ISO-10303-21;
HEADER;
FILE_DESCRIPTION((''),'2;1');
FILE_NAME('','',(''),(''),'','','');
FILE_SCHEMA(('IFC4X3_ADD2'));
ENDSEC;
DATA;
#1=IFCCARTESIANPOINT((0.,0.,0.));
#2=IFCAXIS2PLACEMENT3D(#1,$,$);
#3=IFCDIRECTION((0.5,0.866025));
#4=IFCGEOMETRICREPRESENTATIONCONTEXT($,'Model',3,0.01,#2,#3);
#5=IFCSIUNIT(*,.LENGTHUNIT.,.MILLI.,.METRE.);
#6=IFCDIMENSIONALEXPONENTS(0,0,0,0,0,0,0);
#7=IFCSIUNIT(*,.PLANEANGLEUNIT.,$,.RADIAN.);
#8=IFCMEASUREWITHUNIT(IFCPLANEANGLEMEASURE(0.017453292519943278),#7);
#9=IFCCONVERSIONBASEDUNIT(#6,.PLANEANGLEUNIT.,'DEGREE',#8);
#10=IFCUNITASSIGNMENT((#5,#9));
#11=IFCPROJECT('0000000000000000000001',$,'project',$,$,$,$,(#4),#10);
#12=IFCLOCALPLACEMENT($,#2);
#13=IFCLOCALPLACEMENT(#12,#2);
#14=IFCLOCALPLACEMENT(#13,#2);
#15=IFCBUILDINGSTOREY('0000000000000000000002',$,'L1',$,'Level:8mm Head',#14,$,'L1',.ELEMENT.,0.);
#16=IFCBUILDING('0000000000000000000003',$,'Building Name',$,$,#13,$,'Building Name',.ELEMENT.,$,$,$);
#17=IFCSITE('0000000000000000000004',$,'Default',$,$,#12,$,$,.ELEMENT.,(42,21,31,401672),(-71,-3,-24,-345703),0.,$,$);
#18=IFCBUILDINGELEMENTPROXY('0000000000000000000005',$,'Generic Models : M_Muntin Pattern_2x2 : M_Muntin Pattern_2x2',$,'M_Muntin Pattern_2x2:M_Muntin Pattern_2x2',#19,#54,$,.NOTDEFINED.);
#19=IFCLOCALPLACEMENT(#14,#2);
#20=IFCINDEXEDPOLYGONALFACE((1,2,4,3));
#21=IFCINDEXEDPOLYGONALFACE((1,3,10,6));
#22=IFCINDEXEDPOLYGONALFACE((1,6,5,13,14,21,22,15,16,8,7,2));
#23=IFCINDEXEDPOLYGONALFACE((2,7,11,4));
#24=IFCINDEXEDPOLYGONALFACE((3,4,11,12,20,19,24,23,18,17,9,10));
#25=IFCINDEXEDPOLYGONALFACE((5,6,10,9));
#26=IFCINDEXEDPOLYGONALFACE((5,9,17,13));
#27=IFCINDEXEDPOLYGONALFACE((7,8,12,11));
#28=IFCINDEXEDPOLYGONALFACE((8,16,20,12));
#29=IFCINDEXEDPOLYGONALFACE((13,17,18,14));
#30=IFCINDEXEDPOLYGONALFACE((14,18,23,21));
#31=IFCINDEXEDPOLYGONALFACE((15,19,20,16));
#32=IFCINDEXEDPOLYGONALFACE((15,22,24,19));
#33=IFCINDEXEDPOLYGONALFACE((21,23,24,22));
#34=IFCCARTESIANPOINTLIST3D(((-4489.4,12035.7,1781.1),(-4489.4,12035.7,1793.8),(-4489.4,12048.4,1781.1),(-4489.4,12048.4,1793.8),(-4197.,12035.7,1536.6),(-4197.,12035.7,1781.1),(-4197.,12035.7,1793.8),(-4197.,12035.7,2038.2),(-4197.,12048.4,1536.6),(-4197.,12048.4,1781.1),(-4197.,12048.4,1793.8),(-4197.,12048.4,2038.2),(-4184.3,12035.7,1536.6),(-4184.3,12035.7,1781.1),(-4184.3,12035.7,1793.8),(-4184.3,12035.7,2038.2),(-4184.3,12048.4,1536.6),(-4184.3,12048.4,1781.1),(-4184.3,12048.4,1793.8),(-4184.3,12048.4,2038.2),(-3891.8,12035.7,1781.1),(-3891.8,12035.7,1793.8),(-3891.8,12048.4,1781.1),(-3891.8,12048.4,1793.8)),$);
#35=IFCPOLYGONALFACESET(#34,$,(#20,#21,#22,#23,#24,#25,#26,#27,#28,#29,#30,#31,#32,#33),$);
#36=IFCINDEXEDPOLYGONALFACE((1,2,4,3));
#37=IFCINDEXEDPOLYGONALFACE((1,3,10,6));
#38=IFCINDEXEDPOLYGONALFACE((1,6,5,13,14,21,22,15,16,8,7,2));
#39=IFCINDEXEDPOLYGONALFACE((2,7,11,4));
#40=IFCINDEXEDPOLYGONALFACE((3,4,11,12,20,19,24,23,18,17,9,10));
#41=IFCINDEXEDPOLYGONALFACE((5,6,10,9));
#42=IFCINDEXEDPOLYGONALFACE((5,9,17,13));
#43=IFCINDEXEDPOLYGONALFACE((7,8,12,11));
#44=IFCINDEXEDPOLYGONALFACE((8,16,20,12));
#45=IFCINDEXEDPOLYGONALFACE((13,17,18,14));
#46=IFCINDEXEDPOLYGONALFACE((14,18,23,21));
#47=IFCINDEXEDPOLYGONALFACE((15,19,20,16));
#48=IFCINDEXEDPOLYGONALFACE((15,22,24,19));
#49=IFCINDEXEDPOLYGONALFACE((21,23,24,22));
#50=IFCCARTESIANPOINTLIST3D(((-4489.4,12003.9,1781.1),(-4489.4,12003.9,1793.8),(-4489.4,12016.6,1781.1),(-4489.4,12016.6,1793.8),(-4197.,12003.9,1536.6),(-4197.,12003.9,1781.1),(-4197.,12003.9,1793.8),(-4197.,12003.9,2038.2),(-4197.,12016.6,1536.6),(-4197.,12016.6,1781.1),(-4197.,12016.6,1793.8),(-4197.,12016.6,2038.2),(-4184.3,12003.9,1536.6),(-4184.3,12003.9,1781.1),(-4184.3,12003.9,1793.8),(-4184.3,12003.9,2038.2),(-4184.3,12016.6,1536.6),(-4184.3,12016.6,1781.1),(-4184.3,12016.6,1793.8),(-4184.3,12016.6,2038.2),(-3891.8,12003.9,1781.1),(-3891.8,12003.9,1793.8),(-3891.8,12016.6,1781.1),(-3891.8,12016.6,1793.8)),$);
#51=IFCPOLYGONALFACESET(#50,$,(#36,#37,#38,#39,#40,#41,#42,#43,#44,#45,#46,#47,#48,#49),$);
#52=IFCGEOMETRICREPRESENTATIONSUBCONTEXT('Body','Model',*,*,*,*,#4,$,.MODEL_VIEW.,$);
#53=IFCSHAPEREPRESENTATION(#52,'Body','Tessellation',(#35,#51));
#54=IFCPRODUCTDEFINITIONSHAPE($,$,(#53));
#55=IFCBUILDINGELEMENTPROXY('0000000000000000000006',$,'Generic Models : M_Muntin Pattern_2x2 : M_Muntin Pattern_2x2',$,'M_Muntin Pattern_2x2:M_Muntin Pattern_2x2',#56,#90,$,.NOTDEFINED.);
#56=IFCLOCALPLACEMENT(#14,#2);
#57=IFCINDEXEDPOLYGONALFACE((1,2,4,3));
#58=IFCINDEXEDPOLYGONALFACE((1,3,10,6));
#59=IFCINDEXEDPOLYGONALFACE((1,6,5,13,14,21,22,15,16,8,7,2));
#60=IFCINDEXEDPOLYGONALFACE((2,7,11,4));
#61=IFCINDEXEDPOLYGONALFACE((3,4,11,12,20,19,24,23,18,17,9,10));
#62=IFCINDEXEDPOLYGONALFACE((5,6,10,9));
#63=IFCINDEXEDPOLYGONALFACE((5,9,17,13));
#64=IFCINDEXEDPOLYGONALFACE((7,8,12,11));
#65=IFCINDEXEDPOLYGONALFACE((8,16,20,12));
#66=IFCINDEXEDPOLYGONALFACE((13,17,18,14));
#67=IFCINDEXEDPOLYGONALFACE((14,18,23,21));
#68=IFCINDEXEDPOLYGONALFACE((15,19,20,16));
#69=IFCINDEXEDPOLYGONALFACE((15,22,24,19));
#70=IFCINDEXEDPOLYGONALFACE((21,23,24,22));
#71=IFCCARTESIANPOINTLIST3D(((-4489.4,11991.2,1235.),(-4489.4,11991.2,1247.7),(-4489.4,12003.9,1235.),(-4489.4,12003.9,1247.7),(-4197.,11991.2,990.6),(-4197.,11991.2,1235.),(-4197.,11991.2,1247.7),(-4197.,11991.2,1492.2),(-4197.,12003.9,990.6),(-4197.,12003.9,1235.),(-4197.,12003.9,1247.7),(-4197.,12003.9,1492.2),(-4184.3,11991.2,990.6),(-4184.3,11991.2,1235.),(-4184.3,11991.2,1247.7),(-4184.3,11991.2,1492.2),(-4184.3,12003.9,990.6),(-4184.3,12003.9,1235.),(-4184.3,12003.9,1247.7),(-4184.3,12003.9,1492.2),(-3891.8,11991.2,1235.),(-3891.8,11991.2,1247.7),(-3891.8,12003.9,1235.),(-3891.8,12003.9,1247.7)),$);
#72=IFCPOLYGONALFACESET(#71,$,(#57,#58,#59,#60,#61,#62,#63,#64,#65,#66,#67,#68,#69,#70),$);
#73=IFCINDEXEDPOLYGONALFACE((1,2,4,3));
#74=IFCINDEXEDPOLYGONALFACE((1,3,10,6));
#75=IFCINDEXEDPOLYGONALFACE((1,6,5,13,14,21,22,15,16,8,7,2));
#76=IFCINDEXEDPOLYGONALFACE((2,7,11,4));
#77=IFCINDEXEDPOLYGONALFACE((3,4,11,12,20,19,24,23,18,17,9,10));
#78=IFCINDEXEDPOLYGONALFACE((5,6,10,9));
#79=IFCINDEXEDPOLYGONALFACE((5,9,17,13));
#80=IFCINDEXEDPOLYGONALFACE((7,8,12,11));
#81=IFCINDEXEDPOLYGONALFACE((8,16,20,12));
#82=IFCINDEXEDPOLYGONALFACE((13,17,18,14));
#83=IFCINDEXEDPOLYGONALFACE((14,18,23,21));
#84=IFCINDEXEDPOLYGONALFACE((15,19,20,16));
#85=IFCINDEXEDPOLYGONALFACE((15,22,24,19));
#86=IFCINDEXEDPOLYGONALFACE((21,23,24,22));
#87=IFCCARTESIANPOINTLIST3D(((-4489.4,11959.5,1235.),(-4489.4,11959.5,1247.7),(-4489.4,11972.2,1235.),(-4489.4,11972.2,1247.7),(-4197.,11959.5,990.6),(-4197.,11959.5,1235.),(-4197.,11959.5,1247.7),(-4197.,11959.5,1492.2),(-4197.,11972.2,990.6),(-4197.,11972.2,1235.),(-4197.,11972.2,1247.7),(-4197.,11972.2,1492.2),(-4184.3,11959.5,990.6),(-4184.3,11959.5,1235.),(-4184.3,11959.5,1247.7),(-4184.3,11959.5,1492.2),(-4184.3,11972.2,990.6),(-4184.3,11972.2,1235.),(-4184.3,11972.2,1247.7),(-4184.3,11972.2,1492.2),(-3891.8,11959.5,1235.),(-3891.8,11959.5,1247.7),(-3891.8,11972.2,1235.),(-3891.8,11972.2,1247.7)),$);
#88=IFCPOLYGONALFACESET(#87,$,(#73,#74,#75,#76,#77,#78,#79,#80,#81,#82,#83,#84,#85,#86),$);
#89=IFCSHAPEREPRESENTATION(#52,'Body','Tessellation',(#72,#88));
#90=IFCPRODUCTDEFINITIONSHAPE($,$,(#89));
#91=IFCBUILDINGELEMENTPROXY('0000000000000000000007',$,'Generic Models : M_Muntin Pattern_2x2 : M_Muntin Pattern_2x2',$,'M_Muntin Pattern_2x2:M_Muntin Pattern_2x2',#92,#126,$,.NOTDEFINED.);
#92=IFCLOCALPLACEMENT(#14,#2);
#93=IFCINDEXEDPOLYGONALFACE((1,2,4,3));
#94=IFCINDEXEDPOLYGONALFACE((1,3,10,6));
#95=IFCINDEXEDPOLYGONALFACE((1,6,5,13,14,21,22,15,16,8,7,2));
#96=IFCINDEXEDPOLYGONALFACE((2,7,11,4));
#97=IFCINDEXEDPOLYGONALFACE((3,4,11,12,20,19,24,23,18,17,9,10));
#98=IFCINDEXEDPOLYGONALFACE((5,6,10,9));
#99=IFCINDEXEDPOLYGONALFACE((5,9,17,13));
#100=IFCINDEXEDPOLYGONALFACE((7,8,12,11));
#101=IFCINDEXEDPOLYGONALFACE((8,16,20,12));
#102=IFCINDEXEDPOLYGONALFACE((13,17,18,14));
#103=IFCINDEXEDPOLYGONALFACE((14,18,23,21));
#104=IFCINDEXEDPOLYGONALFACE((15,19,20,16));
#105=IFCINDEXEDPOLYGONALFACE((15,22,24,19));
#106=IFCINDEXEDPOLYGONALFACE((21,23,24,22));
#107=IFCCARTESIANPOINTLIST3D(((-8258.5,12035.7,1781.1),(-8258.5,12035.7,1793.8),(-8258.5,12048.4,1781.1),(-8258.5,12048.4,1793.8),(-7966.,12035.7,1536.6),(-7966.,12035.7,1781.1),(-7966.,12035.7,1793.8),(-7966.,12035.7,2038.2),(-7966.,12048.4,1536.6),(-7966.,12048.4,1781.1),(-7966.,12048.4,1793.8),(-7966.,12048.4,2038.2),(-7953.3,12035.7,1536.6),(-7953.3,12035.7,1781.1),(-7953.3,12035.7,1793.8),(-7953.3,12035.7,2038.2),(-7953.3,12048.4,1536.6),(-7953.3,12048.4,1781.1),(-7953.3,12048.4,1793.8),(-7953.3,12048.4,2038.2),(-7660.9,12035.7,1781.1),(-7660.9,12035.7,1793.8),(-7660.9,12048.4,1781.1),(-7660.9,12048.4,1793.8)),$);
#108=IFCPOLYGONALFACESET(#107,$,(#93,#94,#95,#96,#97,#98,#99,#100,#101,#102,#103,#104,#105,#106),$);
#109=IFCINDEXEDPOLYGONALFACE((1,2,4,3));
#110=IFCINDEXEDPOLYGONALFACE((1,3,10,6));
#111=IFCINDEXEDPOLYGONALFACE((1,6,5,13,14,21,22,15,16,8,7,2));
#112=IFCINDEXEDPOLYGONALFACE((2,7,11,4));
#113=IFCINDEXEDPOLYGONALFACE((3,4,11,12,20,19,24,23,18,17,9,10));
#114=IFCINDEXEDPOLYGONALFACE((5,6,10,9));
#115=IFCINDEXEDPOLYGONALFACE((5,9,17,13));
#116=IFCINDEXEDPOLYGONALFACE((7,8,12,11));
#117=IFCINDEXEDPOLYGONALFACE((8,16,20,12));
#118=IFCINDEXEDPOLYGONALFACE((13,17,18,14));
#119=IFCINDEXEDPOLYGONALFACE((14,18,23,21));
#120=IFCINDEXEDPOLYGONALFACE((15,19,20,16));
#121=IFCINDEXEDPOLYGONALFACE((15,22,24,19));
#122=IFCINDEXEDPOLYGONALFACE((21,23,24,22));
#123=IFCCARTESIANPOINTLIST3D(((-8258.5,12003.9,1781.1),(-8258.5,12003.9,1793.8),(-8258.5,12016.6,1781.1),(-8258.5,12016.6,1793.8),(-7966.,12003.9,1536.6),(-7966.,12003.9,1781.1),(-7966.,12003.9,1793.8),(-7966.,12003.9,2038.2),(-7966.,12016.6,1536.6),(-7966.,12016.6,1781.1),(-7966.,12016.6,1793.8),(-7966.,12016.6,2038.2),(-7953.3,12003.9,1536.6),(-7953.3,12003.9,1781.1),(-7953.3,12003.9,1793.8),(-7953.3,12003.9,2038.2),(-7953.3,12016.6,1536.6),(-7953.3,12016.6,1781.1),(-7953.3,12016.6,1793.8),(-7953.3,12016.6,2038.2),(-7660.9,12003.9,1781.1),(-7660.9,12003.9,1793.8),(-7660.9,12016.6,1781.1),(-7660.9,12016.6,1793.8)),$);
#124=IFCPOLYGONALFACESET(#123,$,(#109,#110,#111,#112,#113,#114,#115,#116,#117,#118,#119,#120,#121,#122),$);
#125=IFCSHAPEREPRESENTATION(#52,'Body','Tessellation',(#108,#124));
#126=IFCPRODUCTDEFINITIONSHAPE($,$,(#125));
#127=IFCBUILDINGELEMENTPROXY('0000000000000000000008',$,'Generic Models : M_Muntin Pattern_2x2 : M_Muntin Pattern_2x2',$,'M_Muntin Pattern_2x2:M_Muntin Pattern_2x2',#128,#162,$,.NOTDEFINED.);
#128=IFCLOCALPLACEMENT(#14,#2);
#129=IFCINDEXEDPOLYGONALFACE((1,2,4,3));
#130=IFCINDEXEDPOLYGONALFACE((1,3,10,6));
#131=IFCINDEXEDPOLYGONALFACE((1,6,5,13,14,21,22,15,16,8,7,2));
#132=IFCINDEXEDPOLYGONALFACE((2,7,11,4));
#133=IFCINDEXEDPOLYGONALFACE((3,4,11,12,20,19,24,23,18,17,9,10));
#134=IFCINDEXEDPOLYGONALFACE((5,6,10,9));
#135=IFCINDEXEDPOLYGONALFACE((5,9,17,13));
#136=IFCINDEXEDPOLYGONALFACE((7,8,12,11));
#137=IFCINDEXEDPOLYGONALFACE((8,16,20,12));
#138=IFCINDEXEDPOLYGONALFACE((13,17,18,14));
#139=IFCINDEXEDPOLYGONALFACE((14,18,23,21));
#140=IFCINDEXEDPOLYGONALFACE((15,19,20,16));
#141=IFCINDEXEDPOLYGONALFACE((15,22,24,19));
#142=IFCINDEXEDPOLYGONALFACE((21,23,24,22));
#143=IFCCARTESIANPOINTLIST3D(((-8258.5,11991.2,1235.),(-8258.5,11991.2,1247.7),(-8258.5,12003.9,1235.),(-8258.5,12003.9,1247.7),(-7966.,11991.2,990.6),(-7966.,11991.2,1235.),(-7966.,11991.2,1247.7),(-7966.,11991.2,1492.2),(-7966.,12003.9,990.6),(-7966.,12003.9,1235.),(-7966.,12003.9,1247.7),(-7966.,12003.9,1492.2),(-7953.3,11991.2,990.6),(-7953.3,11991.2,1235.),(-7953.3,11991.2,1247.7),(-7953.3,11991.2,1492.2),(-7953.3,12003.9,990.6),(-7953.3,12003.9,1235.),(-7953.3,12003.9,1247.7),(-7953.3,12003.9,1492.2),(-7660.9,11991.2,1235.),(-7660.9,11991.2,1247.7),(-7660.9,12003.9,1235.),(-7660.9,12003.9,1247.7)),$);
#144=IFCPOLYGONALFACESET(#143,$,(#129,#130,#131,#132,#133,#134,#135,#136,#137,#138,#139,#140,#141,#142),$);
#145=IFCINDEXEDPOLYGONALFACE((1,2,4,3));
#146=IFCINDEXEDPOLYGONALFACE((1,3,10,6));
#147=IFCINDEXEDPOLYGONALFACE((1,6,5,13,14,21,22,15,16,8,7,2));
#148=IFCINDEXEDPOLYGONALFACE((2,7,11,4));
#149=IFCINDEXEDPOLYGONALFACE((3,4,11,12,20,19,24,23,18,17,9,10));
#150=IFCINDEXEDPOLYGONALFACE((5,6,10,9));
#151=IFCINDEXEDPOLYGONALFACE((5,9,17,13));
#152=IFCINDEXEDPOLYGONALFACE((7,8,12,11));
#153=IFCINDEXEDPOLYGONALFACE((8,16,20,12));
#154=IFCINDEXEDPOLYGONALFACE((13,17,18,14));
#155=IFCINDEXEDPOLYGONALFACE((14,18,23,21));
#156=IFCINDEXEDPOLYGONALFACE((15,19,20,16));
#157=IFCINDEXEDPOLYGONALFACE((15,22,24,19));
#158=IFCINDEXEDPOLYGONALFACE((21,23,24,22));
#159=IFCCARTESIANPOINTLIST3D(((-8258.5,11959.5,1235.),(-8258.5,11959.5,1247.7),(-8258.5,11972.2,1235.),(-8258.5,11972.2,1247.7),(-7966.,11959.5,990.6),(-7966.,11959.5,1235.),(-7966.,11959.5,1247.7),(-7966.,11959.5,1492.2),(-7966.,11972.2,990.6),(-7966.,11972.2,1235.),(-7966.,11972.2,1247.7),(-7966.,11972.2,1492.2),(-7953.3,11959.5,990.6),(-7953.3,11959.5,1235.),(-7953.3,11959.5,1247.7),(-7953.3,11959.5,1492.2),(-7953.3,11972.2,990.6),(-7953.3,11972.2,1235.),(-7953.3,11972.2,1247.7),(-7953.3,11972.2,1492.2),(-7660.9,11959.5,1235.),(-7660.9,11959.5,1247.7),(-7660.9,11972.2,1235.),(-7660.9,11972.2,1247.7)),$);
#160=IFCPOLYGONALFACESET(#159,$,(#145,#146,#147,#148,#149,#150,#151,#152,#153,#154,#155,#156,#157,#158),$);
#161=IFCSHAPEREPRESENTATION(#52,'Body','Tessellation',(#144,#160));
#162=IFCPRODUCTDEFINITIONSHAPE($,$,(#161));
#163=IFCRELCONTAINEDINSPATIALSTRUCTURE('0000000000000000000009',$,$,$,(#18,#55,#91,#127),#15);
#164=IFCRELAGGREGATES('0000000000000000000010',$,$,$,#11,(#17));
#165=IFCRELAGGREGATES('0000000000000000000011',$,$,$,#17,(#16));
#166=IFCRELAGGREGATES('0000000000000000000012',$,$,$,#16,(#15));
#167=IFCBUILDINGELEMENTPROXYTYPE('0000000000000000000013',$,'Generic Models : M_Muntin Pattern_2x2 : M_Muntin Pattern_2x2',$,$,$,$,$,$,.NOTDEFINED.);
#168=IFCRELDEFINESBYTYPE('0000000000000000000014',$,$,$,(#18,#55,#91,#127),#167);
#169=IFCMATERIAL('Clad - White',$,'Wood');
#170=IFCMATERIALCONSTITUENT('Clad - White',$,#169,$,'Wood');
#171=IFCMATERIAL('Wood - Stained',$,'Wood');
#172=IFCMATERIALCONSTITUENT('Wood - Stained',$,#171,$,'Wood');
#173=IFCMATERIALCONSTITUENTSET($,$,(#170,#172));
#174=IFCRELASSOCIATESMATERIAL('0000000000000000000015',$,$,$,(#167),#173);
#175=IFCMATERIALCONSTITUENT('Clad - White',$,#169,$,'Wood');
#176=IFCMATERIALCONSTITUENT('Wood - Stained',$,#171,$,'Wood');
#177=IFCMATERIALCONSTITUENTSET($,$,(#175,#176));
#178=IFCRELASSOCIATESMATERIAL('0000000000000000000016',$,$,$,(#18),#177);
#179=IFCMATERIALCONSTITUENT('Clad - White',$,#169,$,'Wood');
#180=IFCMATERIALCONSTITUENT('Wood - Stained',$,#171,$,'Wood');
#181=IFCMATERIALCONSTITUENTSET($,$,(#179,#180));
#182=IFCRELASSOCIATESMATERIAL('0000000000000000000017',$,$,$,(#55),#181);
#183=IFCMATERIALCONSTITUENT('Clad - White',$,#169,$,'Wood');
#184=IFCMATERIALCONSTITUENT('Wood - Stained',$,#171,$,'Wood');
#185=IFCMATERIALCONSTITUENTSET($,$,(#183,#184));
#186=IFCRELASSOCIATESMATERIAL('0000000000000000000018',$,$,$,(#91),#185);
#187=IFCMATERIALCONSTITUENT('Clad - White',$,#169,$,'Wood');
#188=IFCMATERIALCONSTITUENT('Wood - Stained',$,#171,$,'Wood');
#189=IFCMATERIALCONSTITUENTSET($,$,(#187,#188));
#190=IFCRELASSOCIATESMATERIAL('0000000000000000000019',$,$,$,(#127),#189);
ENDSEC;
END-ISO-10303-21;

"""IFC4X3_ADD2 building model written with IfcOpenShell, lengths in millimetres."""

from ifc_helpers import new_model, entity, si_unit, converted_unit, direction, frame, origin, place, context, subcontext, project, spatial, polyline, outline, extrude, source, transform, mapped, material, constituent, constituent_set, type_object, type_shapes, element, save


model = new_model("IFC4X3_ADD2")

# Units and contexts
model_context = context("Model", 3, precision=0.01, world=origin(), true_north=direction((0.5, 0.866025)))
body_context = subcontext(model_context, "Body", "Model", "MODEL_VIEW")
ifc_project = project(units=[si_unit("LENGTHUNIT", "METRE", prefix="MILLI"), converted_unit("PLANEANGLEUNIT", "DEGREE", entity("IfcPlaneAngleMeasure", 0.017453292519943278), si_unit("PLANEANGLEUNIT", "RADIAN"), dimensions=[0, 0, 0, 0, 0, 0, 0])], contexts=[model_context])

# Site, building, storey
site_placement = place(None, origin())
site = spatial("IfcSite", under=ifc_project, at=site_placement, Name="Default", CompositionType="ELEMENT", RefLatitude=(42, 21, 31, 401672), RefLongitude=(-71, -3, -24, -345703), RefElevation=0.0)
building_placement = place(site_placement, origin())
building = spatial("IfcBuilding", under=site, at=building_placement, Name="Building Name", LongName="Building Name", CompositionType="ELEMENT")
storey_placement = place(building_placement, origin())
storey = spatial("IfcBuildingStorey", under=building, at=storey_placement, Name="L1", ObjectType="Level:8mm Head", LongName="L1", CompositionType="ELEMENT", Elevation=0.0)

# Shared definitions
ifc_material_1 = material(Name="Wood - Stained", Category="Wood")

# Building element proxies
ifc_material_2 = material(Name="Clad - White", Category="Wood")
ifc_constituent_1 = constituent(ifc_material_2, Name="Clad - White", Category="Wood")
ifc_constituent_2 = constituent(ifc_material_1, Name="Wood - Stained", Category="Wood")
ifc_constituent_set_1 = constituent_set(constituents=[ifc_constituent_1, ifc_constituent_2])
building_element_proxy_type_1 = type_object("IfcBuildingElementProxyType", Name="Generic Models : M_Muntin Pattern_2x2 : M_Muntin Pattern_2x2", PredefinedType="NOTDEFINED", material=ifc_constituent_set_1)
shared_shape_1 = source(origin(), body_context, "Body", "SweptSolid", [
    extrude(outline(polyline([(6.4, -6.4), (250.8, -6.4), (250.8, 6.3), (6.4, 6.3), (6.4, 298.8), (-6.3, 298.8), (-6.3, 6.3), (-250.8, 6.3), (-250.8, -6.4), (-6.3, -6.4), (-6.3, -298.8), (6.4, -298.8), (6.4, -6.4)])), frame((0.0, 9.5, 250.8), z_axis=(0.0, 1.0, 0.0), x_axis=(0.0, 0.0, 1.0)), (0.0, 0.0, 1.0), 12.7),
    extrude(outline(polyline([(6.4, -6.4), (250.8, -6.4), (250.8, 6.3), (6.4, 6.3), (6.4, 298.8), (-6.3, 298.8), (-6.3, 6.3), (-250.8, 6.3), (-250.8, -6.4), (-6.3, -6.4), (-6.3, -298.8), (6.4, -298.8), (6.4, -6.4)])), frame((0.0, -22.2, 250.8), z_axis=(0.0, 1.0, 0.0), x_axis=(0.0, 0.0, 1.0)), (0.0, 0.0, 1.0), 12.7),
])
type_shapes(building_element_proxy_type_1, [shared_shape_1])
ifc_constituent_3 = constituent(ifc_material_2, Name="Clad - White", Category="Wood")
ifc_constituent_4 = constituent(ifc_material_1, Name="Wood - Stained", Category="Wood")
ifc_constituent_set_2 = constituent_set(constituents=[ifc_constituent_3, ifc_constituent_4])
proxy_1_placement = place(storey_placement, frame((-4190.6, 12026.1, 1536.6)))
element("IfcBuildingElementProxy", 1, at=proxy_1_placement, inside=storey, type_object=building_element_proxy_type_1, material=ifc_constituent_set_2, Name="Generic Models : M_Muntin Pattern_2x2 : M_Muntin Pattern_2x2", ObjectType="M_Muntin Pattern_2x2:M_Muntin Pattern_2x2", PredefinedType="NOTDEFINED", context=body_context, shape_type="MappedRepresentation", body=[
    mapped(shared_shape_1, transform((0.0, 0.0, 0.0), scale=1.0)),
])
ifc_constituent_5 = constituent(ifc_material_2, Name="Clad - White", Category="Wood")
ifc_constituent_6 = constituent(ifc_material_1, Name="Wood - Stained", Category="Wood")
ifc_constituent_set_3 = constituent_set(constituents=[ifc_constituent_5, ifc_constituent_6])
proxy_2_placement = place(storey_placement, frame((-4190.6, 11981.7, 990.6)))
element("IfcBuildingElementProxy", 2, at=proxy_2_placement, inside=storey, type_object=building_element_proxy_type_1, material=ifc_constituent_set_3, Name="Generic Models : M_Muntin Pattern_2x2 : M_Muntin Pattern_2x2", ObjectType="M_Muntin Pattern_2x2:M_Muntin Pattern_2x2", PredefinedType="NOTDEFINED", context=body_context, shape_type="MappedRepresentation", body=[
    mapped(shared_shape_1, transform((0.0, 0.0, 0.0), scale=1.0)),
])
ifc_constituent_7 = constituent(ifc_material_2, Name="Clad - White", Category="Wood")
ifc_constituent_8 = constituent(ifc_material_1, Name="Wood - Stained", Category="Wood")
ifc_constituent_set_4 = constituent_set(constituents=[ifc_constituent_7, ifc_constituent_8])
proxy_3_placement = place(storey_placement, frame((-7959.7, 12026.1, 1536.6)))
element("IfcBuildingElementProxy", 3, at=proxy_3_placement, inside=storey, type_object=building_element_proxy_type_1, material=ifc_constituent_set_4, Name="Generic Models : M_Muntin Pattern_2x2 : M_Muntin Pattern_2x2", ObjectType="M_Muntin Pattern_2x2:M_Muntin Pattern_2x2", PredefinedType="NOTDEFINED", context=body_context, shape_type="MappedRepresentation", body=[
    mapped(shared_shape_1, transform((0.0, 0.0, 0.0), scale=1.0)),
])
ifc_constituent_9 = constituent(ifc_material_2, Name="Clad - White", Category="Wood")
ifc_constituent_10 = constituent(ifc_material_1, Name="Wood - Stained", Category="Wood")
ifc_constituent_set_5 = constituent_set(constituents=[ifc_constituent_9, ifc_constituent_10])
proxy_4_placement = place(storey_placement, frame((-7959.7, 11981.7, 990.6)))
element("IfcBuildingElementProxy", 4, at=proxy_4_placement, inside=storey, type_object=building_element_proxy_type_1, material=ifc_constituent_set_5, Name="Generic Models : M_Muntin Pattern_2x2 : M_Muntin Pattern_2x2", ObjectType="M_Muntin Pattern_2x2:M_Muntin Pattern_2x2", PredefinedType="NOTDEFINED", context=body_context, shape_type="MappedRepresentation", body=[
    mapped(shared_shape_1, transform((0.0, 0.0, 0.0), scale=1.0)),
])

save(model, "model.ifc")
